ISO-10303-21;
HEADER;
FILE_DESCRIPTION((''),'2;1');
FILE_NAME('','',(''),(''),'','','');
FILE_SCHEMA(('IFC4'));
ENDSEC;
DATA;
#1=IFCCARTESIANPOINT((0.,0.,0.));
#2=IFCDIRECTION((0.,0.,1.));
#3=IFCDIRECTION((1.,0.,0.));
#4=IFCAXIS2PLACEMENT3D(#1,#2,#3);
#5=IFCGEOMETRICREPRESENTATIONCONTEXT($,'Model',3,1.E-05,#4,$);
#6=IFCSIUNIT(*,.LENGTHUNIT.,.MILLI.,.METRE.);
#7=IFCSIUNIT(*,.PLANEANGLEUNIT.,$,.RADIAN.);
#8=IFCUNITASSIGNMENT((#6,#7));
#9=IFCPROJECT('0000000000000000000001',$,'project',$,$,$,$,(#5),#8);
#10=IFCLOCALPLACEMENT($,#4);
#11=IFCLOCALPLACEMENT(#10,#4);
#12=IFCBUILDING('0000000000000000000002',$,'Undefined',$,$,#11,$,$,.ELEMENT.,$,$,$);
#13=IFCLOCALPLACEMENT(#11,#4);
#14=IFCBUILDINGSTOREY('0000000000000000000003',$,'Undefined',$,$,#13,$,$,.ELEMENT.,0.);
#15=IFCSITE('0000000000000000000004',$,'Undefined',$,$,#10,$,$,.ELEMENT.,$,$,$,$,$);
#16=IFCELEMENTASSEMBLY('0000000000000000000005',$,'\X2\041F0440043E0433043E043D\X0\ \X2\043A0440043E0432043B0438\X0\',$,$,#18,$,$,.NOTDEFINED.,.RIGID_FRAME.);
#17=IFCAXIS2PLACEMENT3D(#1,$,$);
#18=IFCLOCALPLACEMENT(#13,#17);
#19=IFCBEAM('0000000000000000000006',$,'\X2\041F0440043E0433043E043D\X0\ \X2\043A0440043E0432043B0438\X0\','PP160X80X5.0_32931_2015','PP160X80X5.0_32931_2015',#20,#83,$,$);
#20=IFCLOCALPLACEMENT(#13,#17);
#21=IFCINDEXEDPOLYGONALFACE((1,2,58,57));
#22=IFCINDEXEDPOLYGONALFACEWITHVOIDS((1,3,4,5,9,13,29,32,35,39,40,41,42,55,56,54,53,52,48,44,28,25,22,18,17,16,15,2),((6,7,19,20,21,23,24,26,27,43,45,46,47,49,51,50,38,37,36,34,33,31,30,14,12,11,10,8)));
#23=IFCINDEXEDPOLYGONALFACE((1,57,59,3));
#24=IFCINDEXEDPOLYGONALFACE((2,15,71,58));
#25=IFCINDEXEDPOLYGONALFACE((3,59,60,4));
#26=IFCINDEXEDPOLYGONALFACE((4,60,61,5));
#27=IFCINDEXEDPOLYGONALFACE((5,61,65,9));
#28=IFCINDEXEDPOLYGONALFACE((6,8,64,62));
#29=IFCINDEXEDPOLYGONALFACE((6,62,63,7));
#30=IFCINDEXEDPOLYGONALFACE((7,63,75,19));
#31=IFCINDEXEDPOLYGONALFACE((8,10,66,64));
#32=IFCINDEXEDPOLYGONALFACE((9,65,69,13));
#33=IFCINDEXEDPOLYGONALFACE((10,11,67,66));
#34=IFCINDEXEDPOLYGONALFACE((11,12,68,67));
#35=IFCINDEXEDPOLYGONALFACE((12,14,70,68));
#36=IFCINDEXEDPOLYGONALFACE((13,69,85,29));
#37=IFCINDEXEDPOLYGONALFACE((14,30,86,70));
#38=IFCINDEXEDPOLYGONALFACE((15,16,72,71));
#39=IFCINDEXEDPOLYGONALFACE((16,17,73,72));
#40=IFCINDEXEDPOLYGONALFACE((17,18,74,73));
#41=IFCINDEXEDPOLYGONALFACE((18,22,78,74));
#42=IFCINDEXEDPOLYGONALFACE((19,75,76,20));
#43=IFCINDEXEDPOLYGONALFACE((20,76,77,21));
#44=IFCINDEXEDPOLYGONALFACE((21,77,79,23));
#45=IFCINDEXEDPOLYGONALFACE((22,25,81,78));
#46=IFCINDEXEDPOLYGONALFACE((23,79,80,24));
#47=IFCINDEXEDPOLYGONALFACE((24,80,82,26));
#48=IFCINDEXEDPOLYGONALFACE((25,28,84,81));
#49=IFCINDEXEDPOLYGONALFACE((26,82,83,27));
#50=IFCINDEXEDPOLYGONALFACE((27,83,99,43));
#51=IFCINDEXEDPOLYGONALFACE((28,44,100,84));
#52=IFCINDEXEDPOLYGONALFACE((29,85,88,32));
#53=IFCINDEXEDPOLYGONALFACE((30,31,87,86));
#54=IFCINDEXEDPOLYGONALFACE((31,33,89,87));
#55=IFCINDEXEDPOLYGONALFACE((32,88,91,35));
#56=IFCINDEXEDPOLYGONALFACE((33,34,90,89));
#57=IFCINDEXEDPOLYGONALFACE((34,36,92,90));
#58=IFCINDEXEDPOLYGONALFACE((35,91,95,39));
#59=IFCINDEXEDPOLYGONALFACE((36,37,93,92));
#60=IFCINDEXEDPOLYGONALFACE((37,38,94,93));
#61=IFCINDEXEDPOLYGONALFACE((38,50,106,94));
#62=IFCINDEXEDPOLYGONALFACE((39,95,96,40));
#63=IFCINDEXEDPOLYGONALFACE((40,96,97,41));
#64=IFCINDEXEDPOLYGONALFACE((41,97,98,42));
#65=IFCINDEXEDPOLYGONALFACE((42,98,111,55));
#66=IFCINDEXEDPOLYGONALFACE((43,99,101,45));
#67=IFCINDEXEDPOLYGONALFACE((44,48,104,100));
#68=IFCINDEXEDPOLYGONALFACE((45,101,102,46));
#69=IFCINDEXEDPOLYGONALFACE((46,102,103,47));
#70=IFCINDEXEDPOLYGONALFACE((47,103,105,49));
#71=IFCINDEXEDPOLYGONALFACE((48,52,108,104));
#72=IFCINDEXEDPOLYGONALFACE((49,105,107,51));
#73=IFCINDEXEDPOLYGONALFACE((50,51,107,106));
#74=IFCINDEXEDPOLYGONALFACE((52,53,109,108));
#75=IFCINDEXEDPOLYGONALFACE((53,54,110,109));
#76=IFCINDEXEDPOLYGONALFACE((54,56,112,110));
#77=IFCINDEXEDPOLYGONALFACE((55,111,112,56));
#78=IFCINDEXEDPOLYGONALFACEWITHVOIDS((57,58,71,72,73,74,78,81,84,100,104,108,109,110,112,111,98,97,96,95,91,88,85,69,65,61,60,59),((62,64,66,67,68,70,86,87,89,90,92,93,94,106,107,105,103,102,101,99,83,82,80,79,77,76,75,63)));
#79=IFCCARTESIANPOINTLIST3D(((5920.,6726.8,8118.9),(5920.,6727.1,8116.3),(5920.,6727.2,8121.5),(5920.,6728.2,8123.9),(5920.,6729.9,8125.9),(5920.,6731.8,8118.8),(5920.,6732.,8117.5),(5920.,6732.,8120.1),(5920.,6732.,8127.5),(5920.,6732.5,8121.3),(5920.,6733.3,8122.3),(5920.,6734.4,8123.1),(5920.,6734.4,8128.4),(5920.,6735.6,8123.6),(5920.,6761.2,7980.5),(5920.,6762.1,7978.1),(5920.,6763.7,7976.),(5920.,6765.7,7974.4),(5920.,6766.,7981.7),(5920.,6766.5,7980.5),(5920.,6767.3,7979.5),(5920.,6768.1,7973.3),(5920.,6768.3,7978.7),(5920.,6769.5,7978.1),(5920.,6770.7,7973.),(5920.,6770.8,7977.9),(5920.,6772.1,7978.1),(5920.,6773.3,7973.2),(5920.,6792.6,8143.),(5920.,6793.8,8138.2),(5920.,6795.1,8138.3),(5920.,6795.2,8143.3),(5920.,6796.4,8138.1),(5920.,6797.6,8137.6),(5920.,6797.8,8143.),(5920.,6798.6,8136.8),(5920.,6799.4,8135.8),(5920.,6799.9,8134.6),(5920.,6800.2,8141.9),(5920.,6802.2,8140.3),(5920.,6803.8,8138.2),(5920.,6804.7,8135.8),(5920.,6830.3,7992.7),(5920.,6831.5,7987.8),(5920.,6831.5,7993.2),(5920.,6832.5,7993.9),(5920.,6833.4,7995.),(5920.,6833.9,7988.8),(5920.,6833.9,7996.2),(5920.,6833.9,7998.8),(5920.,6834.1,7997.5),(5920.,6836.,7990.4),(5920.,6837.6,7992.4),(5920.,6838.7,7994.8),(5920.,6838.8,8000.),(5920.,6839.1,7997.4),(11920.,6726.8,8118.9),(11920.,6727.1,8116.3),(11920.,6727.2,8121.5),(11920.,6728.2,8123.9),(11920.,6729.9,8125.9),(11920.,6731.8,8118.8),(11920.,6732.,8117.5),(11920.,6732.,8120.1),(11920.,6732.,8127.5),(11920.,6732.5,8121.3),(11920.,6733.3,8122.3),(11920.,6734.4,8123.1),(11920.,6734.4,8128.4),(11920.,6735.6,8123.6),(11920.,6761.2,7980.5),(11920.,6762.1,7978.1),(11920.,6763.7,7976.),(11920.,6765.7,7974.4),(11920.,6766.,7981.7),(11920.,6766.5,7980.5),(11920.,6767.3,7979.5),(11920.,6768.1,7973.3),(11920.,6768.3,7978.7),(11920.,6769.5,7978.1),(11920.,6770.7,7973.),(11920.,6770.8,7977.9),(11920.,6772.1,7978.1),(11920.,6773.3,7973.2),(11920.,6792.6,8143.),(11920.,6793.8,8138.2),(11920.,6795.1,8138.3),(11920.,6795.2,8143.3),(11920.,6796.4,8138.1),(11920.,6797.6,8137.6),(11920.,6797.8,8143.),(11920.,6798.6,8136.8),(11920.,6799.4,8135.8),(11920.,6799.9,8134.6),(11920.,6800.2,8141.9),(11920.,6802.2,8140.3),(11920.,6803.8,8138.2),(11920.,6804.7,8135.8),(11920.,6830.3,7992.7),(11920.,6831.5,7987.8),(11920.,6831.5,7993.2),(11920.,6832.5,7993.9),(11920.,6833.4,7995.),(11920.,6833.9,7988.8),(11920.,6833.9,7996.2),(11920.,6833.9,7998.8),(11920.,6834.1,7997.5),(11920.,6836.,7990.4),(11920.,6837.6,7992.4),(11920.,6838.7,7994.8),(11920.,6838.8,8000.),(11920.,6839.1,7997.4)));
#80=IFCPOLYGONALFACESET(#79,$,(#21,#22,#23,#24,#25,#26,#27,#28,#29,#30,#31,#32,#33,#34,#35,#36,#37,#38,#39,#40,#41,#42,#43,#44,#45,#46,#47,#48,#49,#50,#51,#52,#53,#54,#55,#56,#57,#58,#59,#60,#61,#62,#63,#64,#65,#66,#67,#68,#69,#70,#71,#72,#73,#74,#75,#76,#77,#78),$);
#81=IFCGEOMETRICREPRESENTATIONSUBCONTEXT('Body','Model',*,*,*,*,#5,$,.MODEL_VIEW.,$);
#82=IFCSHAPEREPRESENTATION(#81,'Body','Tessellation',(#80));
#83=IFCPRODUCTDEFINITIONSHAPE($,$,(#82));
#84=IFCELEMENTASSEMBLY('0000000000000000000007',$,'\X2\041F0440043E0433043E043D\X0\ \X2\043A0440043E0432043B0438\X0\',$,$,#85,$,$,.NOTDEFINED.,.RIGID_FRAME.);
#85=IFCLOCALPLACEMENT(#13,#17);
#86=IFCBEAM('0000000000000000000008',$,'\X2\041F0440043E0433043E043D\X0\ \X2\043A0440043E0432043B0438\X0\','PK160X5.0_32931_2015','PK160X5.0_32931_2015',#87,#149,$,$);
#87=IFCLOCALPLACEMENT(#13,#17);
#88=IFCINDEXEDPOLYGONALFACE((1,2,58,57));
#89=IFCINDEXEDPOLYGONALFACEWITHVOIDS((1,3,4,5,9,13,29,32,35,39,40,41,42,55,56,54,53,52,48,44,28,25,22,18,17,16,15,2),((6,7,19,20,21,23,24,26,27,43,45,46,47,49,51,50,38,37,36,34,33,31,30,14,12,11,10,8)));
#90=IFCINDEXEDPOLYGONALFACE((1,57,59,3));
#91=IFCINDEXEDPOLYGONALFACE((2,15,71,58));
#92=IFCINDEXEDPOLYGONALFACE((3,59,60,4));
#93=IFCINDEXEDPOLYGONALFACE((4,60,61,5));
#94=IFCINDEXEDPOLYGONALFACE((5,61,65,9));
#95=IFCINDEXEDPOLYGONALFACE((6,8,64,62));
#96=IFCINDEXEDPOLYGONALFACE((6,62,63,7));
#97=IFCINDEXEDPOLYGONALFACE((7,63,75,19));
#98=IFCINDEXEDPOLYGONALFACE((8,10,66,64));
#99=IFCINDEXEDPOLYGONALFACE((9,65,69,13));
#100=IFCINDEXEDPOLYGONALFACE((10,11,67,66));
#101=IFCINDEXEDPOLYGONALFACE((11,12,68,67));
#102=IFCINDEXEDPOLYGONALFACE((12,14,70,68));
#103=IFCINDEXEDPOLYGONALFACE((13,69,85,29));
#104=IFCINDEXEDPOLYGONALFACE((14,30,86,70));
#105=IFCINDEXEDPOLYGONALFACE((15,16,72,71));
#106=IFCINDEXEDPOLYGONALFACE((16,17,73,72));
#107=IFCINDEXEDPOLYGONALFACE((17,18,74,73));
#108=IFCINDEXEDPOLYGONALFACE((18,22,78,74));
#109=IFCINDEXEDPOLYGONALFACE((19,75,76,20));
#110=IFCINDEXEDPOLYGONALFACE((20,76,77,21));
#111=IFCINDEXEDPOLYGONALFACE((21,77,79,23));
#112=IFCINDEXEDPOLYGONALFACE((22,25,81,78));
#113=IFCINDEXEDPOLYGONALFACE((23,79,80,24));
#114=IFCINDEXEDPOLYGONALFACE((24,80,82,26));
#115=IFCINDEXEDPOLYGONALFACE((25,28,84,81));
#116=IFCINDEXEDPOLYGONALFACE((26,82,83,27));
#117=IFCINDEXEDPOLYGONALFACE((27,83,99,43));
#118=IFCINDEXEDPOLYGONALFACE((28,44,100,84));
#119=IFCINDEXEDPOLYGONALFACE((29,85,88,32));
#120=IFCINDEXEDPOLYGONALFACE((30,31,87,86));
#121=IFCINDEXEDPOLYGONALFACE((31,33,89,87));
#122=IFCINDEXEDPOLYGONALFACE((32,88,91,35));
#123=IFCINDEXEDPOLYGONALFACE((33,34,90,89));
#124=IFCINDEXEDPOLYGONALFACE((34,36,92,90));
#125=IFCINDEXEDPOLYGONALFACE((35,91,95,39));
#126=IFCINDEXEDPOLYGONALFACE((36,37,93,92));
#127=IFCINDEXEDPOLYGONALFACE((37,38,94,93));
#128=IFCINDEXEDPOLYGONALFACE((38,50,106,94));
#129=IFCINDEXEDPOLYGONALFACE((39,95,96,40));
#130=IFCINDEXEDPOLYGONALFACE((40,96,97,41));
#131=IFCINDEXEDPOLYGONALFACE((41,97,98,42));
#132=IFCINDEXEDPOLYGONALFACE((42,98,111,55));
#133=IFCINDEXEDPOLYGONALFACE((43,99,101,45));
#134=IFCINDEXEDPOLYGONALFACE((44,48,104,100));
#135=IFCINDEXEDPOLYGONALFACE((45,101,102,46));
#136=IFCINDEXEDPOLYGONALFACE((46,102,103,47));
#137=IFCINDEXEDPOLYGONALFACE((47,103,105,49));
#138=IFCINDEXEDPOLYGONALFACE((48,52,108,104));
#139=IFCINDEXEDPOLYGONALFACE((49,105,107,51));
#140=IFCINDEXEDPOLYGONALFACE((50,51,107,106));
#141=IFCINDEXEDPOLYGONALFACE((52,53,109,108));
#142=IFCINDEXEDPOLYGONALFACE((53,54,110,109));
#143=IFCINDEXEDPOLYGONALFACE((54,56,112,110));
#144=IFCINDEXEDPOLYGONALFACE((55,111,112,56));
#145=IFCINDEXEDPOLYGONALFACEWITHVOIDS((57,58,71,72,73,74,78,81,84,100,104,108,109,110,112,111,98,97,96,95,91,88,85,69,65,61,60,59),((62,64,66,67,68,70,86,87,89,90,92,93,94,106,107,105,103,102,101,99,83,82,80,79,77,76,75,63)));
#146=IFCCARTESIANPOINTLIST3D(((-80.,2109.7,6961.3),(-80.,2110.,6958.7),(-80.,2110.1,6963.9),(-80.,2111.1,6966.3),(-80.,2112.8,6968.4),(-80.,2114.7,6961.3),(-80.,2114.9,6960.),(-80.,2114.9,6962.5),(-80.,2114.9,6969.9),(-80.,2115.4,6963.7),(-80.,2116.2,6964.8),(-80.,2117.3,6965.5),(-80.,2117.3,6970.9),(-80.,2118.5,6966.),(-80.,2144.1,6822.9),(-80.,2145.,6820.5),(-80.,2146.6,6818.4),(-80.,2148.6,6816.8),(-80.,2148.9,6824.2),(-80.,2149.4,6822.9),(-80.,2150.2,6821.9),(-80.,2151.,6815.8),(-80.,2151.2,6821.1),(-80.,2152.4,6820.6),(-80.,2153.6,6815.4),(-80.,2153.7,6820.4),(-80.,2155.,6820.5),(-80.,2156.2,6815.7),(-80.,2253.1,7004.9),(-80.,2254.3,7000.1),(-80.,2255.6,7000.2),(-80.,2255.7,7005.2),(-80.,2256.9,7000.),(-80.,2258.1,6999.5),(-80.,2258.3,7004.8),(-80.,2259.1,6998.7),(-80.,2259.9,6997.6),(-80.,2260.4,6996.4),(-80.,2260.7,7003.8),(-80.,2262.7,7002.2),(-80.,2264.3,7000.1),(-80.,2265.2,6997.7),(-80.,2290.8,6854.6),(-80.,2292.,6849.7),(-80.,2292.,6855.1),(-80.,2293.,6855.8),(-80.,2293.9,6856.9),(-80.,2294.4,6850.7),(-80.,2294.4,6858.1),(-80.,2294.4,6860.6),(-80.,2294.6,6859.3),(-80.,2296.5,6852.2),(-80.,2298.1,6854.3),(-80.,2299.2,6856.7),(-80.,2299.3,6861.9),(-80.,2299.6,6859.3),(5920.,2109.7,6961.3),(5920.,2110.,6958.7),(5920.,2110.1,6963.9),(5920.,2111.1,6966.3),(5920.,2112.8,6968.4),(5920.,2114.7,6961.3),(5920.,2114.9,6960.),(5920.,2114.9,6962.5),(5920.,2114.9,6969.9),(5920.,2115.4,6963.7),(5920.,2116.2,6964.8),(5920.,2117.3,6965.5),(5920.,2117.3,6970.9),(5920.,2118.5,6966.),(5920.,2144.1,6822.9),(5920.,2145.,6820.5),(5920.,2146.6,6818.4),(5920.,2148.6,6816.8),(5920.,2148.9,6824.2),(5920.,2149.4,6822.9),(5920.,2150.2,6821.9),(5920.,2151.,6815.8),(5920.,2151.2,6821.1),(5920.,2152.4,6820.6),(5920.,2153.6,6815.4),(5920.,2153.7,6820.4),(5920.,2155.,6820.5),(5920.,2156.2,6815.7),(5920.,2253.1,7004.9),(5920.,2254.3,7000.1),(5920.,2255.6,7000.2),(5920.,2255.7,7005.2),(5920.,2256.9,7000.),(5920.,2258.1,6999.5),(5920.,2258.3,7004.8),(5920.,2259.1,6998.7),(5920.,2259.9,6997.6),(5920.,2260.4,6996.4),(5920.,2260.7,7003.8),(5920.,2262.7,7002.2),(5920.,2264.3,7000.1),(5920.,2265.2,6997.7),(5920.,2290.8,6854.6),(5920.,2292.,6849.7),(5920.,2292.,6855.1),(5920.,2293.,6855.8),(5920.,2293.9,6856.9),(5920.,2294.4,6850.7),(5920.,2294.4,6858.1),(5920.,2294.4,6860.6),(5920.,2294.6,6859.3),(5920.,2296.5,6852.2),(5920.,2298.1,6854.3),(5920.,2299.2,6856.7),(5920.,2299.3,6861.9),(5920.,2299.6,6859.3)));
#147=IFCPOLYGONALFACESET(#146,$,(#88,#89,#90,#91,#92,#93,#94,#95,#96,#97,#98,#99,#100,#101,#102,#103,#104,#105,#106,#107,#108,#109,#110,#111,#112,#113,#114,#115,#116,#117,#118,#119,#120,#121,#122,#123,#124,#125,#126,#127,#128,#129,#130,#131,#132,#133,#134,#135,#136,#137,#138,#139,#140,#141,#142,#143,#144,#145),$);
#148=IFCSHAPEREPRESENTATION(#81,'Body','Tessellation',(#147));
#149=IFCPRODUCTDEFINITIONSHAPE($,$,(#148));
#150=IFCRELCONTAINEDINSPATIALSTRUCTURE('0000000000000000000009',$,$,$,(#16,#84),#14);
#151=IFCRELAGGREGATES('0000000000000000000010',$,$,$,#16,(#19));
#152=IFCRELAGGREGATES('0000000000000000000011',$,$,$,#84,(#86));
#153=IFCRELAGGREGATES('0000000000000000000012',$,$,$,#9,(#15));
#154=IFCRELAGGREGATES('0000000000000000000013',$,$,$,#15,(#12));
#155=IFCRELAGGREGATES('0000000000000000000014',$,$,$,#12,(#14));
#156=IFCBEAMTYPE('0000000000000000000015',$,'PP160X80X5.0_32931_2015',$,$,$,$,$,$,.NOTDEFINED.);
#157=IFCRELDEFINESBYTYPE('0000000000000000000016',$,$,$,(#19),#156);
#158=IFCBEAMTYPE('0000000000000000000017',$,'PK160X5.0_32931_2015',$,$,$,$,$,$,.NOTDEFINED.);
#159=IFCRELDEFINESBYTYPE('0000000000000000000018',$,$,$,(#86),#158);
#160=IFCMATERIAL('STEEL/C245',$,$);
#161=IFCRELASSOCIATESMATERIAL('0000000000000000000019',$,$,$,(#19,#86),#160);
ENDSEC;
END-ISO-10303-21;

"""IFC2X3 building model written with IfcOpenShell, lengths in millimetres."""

from ifc_helpers import new_model, si_unit, frame, origin_with_axes, origin_2d_with_axis, place, context, subcontext, project, spatial, hollow_rectangle, extrude, material, type_object, element, aggregate, save


model = new_model("IFC2X3")

# Units and contexts
model_context = context("Model", 3, precision=1e-05, world=origin_with_axes())
body_context = subcontext(model_context, "Body", "Model", "MODEL_VIEW")
ifc_project = project(units=[si_unit("LENGTHUNIT", "METRE", prefix="MILLI"), si_unit("PLANEANGLEUNIT", "RADIAN")], contexts=[model_context])

# Site, building, storey
site_placement = place(None, origin_with_axes())
site = spatial("IfcSite", under=ifc_project, at=site_placement, Name="Undefined", CompositionType="ELEMENT")
building_placement = place(site_placement, origin_with_axes())
building = spatial("IfcBuilding", under=site, at=building_placement, Name="Undefined", CompositionType="ELEMENT")
storey_placement = place(building_placement, origin_with_axes())
storey = spatial("IfcBuildingStorey", under=building, at=storey_placement, Name="Undefined", CompositionType="ELEMENT", Elevation=0.0)

# Shared definitions
ifc_material = material(Name="STEEL/C245")

# Element assemblies, beams
beam_type_1 = type_object("IfcBeamType", Name="PP160X80X5.0_32931_2015", PredefinedType="NOTDEFINED")
assembly_1_placement = place(storey_placement, origin_with_axes())
assembly_1 = element("IfcElementAssembly", 1, at=assembly_1_placement, inside=storey, Name="Прогон кровли", AssemblyPlace="NOTDEFINED", PredefinedType="RIGID_FRAME")
beam_1_placement = place(assembly_1_placement, frame((5920.0, 6782.9, 8058.1), z_axis=(0.0, -0.243188, 0.969979), x_axis=(1.0, 0.0, 0.0)))
beam_1 = element("IfcBeam", 2, at=beam_1_placement, type_object=beam_type_1, material=ifc_material, Name="Прогон кровли", Description="PP160X80X5.0_32931_2015", ObjectType="PP160X80X5.0_32931_2015", context=body_context, shape_type="SweptSolid", body=[
    extrude(hollow_rectangle(XDim=80.0, YDim=160.0, WallThickness=5.0, InnerFilletRadius=5.0, OuterFilletRadius=10.0, at=origin_2d_with_axis()), frame((6000.0, 0.0, 0.0), z_axis=(-1.0, 0.0, 0.0), x_axis=(0.0, -1.0, 0.0)), (0.0, 0.0, 1.0), 6000.0),
])
aggregate(assembly_1, [beam_1])
assembly_2_placement = place(storey_placement, origin_with_axes())
assembly_2 = element("IfcElementAssembly", 3, at=assembly_2_placement, inside=storey, Name="Прогон кровли", AssemblyPlace="NOTDEFINED", PredefinedType="RIGID_FRAME")
beam_type_2 = type_object("IfcBeamType", Name="PK160X5.0_32931_2015", PredefinedType="NOTDEFINED")
beam_2_placement = place(assembly_2_placement, frame((-80.0, 2204.6, 6910.3), z_axis=(0.0, -0.243188, 0.969979), x_axis=(1.0, 0.0, 0.0)))
beam_2 = element("IfcBeam", 4, at=beam_2_placement, type_object=beam_type_2, material=ifc_material, Name="Прогон кровли", Description="PK160X5.0_32931_2015", ObjectType="PK160X5.0_32931_2015", context=body_context, shape_type="SweptSolid", body=[
    extrude(hollow_rectangle(XDim=160.0, YDim=160.0, WallThickness=5.0, InnerFilletRadius=5.0, OuterFilletRadius=10.0, at=origin_2d_with_axis()), frame((6000.0, 0.0, 0.0), z_axis=(-1.0, 0.0, 0.0), x_axis=(0.0, -1.0, 0.0)), (0.0, 0.0, 1.0), 6000.0),
])
aggregate(assembly_2, [beam_2])

save(model, "model.ifc")
